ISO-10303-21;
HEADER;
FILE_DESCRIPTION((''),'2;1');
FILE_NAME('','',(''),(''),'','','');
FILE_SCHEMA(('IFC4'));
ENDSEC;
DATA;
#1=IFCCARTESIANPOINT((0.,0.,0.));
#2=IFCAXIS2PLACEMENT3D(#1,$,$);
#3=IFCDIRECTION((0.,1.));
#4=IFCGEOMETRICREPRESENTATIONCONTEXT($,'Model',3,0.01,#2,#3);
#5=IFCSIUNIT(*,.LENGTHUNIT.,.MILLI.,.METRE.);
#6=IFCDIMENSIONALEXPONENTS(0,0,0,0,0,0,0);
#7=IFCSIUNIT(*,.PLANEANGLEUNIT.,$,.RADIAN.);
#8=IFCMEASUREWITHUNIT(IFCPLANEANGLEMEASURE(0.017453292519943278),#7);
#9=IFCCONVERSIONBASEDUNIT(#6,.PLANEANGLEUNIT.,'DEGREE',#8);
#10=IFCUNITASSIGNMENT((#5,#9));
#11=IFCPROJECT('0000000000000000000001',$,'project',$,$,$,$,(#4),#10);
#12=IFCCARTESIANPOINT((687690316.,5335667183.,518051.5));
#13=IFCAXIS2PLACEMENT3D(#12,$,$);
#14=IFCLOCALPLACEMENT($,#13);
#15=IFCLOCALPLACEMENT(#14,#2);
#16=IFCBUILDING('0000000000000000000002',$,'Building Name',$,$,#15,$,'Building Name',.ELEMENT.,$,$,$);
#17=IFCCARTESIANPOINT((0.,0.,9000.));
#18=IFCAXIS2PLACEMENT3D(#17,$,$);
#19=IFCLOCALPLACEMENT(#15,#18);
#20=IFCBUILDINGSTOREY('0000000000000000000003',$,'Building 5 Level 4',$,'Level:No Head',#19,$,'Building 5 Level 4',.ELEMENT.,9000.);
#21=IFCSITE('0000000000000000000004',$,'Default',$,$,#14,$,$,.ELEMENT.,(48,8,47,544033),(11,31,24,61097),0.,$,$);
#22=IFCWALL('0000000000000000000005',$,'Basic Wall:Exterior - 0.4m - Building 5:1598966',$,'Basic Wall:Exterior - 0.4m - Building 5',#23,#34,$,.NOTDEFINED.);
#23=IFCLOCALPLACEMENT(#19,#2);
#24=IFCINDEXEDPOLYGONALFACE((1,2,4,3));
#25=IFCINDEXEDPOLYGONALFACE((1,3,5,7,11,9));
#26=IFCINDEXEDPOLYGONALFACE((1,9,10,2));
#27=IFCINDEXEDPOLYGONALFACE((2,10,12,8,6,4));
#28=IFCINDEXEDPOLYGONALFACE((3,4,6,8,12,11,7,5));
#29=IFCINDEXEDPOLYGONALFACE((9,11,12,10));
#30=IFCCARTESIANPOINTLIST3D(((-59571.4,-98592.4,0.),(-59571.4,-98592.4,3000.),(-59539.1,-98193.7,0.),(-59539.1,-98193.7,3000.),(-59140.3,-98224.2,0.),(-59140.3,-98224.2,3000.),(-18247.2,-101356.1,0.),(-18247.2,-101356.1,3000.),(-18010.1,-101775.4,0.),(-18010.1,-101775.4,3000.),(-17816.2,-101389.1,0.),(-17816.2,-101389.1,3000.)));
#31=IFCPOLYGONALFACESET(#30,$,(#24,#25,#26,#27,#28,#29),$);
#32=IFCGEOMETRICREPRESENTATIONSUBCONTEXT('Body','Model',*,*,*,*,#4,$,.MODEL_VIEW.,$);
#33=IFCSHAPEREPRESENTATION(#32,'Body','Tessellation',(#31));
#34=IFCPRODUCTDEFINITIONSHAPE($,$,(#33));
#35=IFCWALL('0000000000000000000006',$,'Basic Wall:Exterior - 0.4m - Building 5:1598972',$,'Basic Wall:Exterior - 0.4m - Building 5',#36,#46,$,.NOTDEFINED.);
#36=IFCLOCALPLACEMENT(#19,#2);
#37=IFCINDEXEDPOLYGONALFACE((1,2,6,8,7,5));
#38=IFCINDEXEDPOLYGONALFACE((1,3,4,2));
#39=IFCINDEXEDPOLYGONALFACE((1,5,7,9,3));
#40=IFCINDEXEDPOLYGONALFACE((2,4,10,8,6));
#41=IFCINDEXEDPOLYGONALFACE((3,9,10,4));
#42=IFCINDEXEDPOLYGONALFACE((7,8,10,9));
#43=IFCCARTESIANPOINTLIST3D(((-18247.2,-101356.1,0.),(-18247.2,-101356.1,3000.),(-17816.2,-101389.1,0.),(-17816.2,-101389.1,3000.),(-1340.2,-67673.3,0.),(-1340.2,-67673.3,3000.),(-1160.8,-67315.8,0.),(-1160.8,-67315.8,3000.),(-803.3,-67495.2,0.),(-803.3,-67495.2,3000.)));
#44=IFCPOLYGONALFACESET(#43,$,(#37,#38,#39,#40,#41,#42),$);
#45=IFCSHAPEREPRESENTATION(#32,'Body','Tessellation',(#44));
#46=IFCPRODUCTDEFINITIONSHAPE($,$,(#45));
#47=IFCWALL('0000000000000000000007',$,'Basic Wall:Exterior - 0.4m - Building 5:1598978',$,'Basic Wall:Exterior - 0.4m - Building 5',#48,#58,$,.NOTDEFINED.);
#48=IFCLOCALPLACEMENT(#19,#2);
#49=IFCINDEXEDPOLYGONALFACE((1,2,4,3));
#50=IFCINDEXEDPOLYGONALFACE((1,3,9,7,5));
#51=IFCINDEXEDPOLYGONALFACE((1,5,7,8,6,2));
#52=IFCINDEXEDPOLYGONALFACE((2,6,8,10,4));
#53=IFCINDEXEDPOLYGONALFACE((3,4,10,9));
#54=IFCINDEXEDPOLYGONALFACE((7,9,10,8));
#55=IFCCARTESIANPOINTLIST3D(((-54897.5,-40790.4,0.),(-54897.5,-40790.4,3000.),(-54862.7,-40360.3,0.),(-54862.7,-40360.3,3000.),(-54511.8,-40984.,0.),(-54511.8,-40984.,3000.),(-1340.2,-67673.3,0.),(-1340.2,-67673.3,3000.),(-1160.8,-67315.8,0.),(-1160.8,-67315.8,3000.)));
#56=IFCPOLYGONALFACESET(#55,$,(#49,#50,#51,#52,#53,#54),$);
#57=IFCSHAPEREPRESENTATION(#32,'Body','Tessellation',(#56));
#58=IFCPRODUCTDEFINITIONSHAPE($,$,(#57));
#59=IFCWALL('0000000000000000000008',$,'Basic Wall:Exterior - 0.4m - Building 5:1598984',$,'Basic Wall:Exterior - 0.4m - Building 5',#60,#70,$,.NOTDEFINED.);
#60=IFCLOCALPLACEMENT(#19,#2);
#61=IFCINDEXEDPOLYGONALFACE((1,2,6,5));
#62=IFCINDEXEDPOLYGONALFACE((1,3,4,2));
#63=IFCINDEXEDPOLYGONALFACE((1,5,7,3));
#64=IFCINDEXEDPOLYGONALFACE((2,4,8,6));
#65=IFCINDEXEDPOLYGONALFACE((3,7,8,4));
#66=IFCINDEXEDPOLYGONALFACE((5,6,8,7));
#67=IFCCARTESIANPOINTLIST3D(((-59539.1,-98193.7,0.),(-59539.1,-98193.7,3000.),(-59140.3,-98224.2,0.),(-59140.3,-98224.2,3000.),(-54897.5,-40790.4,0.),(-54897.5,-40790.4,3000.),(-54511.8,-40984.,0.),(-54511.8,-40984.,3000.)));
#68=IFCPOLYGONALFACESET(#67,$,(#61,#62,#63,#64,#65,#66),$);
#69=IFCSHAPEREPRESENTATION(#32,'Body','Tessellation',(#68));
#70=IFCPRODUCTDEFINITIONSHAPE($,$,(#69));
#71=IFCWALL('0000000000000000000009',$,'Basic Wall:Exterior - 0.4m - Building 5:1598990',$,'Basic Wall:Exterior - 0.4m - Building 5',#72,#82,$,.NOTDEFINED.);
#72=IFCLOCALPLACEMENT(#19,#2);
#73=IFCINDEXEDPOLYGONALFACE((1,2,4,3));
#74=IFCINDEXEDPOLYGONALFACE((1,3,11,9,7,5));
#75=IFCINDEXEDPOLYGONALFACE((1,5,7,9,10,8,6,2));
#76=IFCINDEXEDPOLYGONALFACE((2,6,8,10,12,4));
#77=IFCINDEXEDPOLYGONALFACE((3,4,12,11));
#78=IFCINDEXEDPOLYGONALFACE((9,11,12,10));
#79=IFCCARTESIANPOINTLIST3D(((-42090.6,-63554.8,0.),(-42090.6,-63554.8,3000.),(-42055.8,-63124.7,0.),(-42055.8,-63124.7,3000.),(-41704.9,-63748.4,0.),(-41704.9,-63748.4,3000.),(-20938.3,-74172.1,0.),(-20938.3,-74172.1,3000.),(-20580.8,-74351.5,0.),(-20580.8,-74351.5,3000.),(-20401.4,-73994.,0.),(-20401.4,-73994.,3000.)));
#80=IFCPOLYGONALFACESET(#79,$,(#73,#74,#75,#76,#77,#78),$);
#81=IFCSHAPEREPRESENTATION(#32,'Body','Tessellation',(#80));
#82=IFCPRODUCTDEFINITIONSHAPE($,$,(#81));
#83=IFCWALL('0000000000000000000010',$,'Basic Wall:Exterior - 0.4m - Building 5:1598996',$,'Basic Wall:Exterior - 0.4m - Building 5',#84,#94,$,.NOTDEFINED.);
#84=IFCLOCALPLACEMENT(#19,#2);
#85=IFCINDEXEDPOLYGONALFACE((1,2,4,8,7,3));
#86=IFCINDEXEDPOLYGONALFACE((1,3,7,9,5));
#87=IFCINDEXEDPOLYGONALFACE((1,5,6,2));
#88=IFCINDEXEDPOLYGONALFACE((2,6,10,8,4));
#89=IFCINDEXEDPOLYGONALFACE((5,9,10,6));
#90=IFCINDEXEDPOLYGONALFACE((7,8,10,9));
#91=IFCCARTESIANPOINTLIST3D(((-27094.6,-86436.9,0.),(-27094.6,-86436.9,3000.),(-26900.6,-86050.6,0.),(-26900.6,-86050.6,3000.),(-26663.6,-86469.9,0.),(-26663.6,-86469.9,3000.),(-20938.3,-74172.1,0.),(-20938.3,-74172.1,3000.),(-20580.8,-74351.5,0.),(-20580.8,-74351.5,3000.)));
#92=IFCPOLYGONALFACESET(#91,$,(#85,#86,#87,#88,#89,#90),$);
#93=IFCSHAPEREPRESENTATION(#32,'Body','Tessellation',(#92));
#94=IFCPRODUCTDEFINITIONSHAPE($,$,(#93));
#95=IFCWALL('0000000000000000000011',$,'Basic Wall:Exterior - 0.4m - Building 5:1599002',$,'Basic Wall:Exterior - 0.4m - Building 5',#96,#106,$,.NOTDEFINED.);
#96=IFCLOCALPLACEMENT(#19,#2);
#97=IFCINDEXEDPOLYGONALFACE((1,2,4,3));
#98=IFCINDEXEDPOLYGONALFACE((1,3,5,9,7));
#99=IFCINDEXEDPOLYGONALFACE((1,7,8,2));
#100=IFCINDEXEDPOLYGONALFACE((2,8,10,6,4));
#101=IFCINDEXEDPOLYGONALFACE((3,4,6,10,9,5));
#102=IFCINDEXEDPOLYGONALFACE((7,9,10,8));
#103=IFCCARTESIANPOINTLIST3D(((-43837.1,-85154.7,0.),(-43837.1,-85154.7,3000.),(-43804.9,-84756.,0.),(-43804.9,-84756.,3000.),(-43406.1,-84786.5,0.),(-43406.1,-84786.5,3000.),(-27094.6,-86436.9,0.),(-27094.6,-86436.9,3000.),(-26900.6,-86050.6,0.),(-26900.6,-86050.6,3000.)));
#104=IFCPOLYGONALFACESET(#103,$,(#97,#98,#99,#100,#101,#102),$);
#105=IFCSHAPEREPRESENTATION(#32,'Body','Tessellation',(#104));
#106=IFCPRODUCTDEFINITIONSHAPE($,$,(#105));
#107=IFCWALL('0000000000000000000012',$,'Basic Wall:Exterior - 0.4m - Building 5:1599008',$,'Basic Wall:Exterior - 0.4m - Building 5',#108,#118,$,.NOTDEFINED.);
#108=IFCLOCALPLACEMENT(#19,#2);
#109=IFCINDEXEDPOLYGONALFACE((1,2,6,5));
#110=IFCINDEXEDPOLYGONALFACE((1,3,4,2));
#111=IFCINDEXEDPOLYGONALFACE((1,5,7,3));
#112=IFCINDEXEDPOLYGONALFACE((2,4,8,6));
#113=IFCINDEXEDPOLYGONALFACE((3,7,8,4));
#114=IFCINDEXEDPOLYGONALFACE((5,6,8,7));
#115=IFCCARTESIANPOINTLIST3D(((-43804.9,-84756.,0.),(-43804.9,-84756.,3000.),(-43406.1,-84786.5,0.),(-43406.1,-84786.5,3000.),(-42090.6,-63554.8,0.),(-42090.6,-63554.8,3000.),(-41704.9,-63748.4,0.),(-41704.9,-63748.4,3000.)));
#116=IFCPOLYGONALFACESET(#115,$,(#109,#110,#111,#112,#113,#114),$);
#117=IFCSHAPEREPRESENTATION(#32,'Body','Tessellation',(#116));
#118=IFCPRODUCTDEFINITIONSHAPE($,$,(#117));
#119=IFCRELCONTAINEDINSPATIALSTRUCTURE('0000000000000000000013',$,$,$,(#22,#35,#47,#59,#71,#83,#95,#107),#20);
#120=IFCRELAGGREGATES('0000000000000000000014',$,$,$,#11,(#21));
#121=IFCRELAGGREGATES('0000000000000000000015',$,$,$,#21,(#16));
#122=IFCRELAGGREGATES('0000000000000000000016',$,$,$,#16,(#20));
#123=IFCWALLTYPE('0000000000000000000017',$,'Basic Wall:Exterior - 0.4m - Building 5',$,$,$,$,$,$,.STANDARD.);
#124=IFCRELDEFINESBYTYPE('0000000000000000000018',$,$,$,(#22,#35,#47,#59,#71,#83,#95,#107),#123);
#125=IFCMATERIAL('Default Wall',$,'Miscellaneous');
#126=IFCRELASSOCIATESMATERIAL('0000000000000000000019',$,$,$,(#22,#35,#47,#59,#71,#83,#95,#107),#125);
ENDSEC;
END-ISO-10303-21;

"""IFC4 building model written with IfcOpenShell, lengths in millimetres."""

from ifc_helpers import new_model, entity, si_unit, converted_unit, direction, frame, origin, place, context, subcontext, project, spatial, indexed_curve, outline, extrude, material, type_object, element, save


model = new_model("IFC4")

# Units and contexts
model_context = context("Model", 3, precision=0.01, world=origin(), true_north=direction((0.0, 1.0)))
body_context = subcontext(model_context, "Body", "Model", "MODEL_VIEW")
ifc_project = project(units=[si_unit("LENGTHUNIT", "METRE", prefix="MILLI"), converted_unit("PLANEANGLEUNIT", "DEGREE", entity("IfcPlaneAngleMeasure", 0.017453292519943278), si_unit("PLANEANGLEUNIT", "RADIAN"), dimensions=[0, 0, 0, 0, 0, 0, 0])], contexts=[model_context])

# Site, building, storey
site_placement = place(None, frame((687690316.0, 5335667183.0, 518051.5)))
site = spatial("IfcSite", under=ifc_project, at=site_placement, Name="Default", CompositionType="ELEMENT", RefLatitude=(48, 8, 47, 544033), RefLongitude=(11, 31, 24, 61097), RefElevation=0.0)
building_placement = place(site_placement, origin())
building = spatial("IfcBuilding", under=site, at=building_placement, Name="Building Name", LongName="Building Name", CompositionType="ELEMENT")
storey_placement = place(building_placement, frame((0.0, 0.0, 9000.0)))
storey = spatial("IfcBuildingStorey", under=building, at=storey_placement, Name="Building 5 Level 4", ObjectType="Level:No Head", LongName="Building 5 Level 4", CompositionType="ELEMENT", Elevation=9000.0)

# Walls
ifc_material_1 = material(Name="Default Wall", Category="Miscellaneous")
wall_type = type_object("IfcWallType", Name="Basic Wall:Exterior - 0.4m - Building 5", PredefinedType="STANDARD")
wall_1_placement = place(storey_placement, frame((-59556.1, -98393.0, 0.0), z_axis=(0.0, 0.0, 1.0), x_axis=(0.99708, -0.076363, 0.0)))
element("IfcWall", 1, at=wall_1_placement, inside=storey, type_object=wall_type, material=ifc_material_1, Name="Basic Wall:Exterior - 0.4m - Building 5:1598966", ObjectType="Basic Wall:Exterior - 0.4m - Building 5", PredefinedType="NOTDEFINED", context=body_context, shape_type="SweptSolid", body=[
    extrude(outline(indexed_curve([(41683.0, -200.0), (41846.9, 200.0), (41414.6, 200.0), (401.7, 200.0), (1.7, 200.0), (0.0, -200.0), (41683.0, -200.0)], self_intersect=False)), origin(), (0.0, 0.0, 1.0), 3000.0),
])
wall_2_placement = place(storey_placement, frame((-18068.4, -101445.8, 0.0), z_axis=(0.0, 0.0, 1.0), x_axis=(0.448604, 0.893731, 0.0)))
element("IfcWall", 2, at=wall_2_placement, inside=storey, type_object=wall_type, material=ifc_material_1, Name="Basic Wall:Exterior - 0.4m - Building 5:1598972", ObjectType="Basic Wall:Exterior - 0.4m - Building 5", PredefinedType="NOTDEFINED", context=body_context, shape_type="SweptSolid", body=[
    extrude(outline(indexed_curve([(38087.9, -200.0), (38087.9, 200.0), (37687.9, 200.0), (0.0, 200.0), (163.8, -200.0), (38087.9, -200.0)], self_intersect=False)), origin(), (0.0, 0.0, 1.0), 3000.0),
])
wall_3_placement = place(storey_placement, frame((-1250.5, -67494.5, 0.0), z_axis=(0.0, 0.0, 1.0), x_axis=(-0.893731, 0.448604, 0.0)))
element("IfcWall", 3, at=wall_3_placement, inside=storey, type_object=wall_type, material=ifc_material_1, Name="Basic Wall:Exterior - 0.4m - Building 5:1598978", ObjectType="Basic Wall:Exterior - 0.4m - Building 5", PredefinedType="NOTDEFINED", context=body_context, shape_type="SweptSolid", body=[
    extrude(outline(indexed_curve([(60087.4, -200.0), (59925.5, 200.0), (59494.0, 200.0), (0.0, 200.0), (0.0, -200.0), (60087.4, -200.0)], self_intersect=False)), origin(), (0.0, 0.0, 1.0), 3000.0),
])
wall_4_placement = place(storey_placement, frame((-54698.1, -40806.5, 0.0), z_axis=(0.0, 0.0, 1.0), x_axis=(-0.080597, -0.996747, 0.0)))
element("IfcWall", 4, at=wall_4_placement, inside=storey, type_object=wall_type, material=ifc_material_1, Name="Basic Wall:Exterior - 0.4m - Building 5:1598984", ObjectType="Basic Wall:Exterior - 0.4m - Building 5", PredefinedType="NOTDEFINED", context=body_context, shape_type="SweptSolid", body=[
    extrude(outline(indexed_curve([(57590.6, -200.0), (57588.9, 200.0), (161.9, 200.0), (0.0, -200.0), (57590.6, -200.0)], self_intersect=False)), origin(), (0.0, 0.0, 1.0), 3000.0),
])
wall_5_placement = place(storey_placement, frame((-42145.5, -63303.4, 0.0), z_axis=(0.0, 0.0, 1.0), x_axis=(0.893731, -0.448604, 0.0)))
element("IfcWall", 5, at=wall_5_placement, inside=storey, type_object=wall_type, material=ifc_material_1, Name="Basic Wall:Exterior - 0.4m - Building 5:1598990", ObjectType="Basic Wall:Exterior - 0.4m - Building 5", PredefinedType="NOTDEFINED", context=body_context, shape_type="SweptSolid", body=[
    extrude(outline(indexed_curve([(24229.3, -200.0), (24229.3, 200.0), (0.0, 200.0), (161.9, -200.0), (593.4, -200.0), (23829.3, -200.0), (24229.3, -200.0)], self_intersect=False)), origin(), (0.0, 0.0, 1.0), 3000.0),
])
wall_6_placement = place(storey_placement, frame((-20759.5, -74261.8, 0.0), z_axis=(0.0, 0.0, 1.0), x_axis=(-0.448604, -0.893731, 0.0)))
element("IfcWall", 6, at=wall_6_placement, inside=storey, type_object=wall_type, material=ifc_material_1, Name="Basic Wall:Exterior - 0.4m - Building 5:1598996", ObjectType="Basic Wall:Exterior - 0.4m - Building 5", PredefinedType="NOTDEFINED", context=body_context, shape_type="SweptSolid", body=[
    extrude(outline(indexed_curve([(13723.2, -200.0), (13559.3, 200.0), (0.0, 200.0), (0.0, -200.0), (13290.9, -200.0), (13723.2, -200.0)], self_intersect=False)), origin(), (0.0, 0.0, 1.0), 3000.0),
])
wall_7_placement = place(storey_placement, frame((-26915.9, -86250.0, 0.0), z_axis=(0.0, 0.0, 1.0), x_axis=(-0.99708, 0.076363, 0.0)))
element("IfcWall", 7, at=wall_7_placement, inside=storey, type_object=wall_type, material=ifc_material_1, Name="Basic Wall:Exterior - 0.4m - Building 5:1599002", ObjectType="Basic Wall:Exterior - 0.4m - Building 5", PredefinedType="NOTDEFINED", context=body_context, shape_type="SweptSolid", body=[
    extrude(outline(indexed_curve([(16953.8, -200.0), (16955.5, 200.0), (163.8, 200.0), (0.0, -200.0), (16553.8, -200.0), (16953.8, -200.0)], self_intersect=False)), origin(), (0.0, 0.0, 1.0), 3000.0),
])
wall_8_placement = place(storey_placement, frame((-43605.6, -84772.1, 0.0), z_axis=(0.0, 0.0, 1.0), x_axis=(0.080597, 0.996747, 0.0)))
element("IfcWall", 8, at=wall_8_placement, inside=storey, type_object=wall_type, material=ifc_material_1, Name="Basic Wall:Exterior - 0.4m - Building 5:1599008", ObjectType="Basic Wall:Exterior - 0.4m - Building 5", PredefinedType="NOTDEFINED", context=body_context, shape_type="SweptSolid", body=[
    extrude(outline(indexed_curve([(21108.5, -200.0), (21270.4, 200.0), (0.0, 200.0), (1.7, -200.0), (21108.5, -200.0)], self_intersect=False)), origin(), (0.0, 0.0, 1.0), 3000.0),
])

save(model, "model.ifc")
